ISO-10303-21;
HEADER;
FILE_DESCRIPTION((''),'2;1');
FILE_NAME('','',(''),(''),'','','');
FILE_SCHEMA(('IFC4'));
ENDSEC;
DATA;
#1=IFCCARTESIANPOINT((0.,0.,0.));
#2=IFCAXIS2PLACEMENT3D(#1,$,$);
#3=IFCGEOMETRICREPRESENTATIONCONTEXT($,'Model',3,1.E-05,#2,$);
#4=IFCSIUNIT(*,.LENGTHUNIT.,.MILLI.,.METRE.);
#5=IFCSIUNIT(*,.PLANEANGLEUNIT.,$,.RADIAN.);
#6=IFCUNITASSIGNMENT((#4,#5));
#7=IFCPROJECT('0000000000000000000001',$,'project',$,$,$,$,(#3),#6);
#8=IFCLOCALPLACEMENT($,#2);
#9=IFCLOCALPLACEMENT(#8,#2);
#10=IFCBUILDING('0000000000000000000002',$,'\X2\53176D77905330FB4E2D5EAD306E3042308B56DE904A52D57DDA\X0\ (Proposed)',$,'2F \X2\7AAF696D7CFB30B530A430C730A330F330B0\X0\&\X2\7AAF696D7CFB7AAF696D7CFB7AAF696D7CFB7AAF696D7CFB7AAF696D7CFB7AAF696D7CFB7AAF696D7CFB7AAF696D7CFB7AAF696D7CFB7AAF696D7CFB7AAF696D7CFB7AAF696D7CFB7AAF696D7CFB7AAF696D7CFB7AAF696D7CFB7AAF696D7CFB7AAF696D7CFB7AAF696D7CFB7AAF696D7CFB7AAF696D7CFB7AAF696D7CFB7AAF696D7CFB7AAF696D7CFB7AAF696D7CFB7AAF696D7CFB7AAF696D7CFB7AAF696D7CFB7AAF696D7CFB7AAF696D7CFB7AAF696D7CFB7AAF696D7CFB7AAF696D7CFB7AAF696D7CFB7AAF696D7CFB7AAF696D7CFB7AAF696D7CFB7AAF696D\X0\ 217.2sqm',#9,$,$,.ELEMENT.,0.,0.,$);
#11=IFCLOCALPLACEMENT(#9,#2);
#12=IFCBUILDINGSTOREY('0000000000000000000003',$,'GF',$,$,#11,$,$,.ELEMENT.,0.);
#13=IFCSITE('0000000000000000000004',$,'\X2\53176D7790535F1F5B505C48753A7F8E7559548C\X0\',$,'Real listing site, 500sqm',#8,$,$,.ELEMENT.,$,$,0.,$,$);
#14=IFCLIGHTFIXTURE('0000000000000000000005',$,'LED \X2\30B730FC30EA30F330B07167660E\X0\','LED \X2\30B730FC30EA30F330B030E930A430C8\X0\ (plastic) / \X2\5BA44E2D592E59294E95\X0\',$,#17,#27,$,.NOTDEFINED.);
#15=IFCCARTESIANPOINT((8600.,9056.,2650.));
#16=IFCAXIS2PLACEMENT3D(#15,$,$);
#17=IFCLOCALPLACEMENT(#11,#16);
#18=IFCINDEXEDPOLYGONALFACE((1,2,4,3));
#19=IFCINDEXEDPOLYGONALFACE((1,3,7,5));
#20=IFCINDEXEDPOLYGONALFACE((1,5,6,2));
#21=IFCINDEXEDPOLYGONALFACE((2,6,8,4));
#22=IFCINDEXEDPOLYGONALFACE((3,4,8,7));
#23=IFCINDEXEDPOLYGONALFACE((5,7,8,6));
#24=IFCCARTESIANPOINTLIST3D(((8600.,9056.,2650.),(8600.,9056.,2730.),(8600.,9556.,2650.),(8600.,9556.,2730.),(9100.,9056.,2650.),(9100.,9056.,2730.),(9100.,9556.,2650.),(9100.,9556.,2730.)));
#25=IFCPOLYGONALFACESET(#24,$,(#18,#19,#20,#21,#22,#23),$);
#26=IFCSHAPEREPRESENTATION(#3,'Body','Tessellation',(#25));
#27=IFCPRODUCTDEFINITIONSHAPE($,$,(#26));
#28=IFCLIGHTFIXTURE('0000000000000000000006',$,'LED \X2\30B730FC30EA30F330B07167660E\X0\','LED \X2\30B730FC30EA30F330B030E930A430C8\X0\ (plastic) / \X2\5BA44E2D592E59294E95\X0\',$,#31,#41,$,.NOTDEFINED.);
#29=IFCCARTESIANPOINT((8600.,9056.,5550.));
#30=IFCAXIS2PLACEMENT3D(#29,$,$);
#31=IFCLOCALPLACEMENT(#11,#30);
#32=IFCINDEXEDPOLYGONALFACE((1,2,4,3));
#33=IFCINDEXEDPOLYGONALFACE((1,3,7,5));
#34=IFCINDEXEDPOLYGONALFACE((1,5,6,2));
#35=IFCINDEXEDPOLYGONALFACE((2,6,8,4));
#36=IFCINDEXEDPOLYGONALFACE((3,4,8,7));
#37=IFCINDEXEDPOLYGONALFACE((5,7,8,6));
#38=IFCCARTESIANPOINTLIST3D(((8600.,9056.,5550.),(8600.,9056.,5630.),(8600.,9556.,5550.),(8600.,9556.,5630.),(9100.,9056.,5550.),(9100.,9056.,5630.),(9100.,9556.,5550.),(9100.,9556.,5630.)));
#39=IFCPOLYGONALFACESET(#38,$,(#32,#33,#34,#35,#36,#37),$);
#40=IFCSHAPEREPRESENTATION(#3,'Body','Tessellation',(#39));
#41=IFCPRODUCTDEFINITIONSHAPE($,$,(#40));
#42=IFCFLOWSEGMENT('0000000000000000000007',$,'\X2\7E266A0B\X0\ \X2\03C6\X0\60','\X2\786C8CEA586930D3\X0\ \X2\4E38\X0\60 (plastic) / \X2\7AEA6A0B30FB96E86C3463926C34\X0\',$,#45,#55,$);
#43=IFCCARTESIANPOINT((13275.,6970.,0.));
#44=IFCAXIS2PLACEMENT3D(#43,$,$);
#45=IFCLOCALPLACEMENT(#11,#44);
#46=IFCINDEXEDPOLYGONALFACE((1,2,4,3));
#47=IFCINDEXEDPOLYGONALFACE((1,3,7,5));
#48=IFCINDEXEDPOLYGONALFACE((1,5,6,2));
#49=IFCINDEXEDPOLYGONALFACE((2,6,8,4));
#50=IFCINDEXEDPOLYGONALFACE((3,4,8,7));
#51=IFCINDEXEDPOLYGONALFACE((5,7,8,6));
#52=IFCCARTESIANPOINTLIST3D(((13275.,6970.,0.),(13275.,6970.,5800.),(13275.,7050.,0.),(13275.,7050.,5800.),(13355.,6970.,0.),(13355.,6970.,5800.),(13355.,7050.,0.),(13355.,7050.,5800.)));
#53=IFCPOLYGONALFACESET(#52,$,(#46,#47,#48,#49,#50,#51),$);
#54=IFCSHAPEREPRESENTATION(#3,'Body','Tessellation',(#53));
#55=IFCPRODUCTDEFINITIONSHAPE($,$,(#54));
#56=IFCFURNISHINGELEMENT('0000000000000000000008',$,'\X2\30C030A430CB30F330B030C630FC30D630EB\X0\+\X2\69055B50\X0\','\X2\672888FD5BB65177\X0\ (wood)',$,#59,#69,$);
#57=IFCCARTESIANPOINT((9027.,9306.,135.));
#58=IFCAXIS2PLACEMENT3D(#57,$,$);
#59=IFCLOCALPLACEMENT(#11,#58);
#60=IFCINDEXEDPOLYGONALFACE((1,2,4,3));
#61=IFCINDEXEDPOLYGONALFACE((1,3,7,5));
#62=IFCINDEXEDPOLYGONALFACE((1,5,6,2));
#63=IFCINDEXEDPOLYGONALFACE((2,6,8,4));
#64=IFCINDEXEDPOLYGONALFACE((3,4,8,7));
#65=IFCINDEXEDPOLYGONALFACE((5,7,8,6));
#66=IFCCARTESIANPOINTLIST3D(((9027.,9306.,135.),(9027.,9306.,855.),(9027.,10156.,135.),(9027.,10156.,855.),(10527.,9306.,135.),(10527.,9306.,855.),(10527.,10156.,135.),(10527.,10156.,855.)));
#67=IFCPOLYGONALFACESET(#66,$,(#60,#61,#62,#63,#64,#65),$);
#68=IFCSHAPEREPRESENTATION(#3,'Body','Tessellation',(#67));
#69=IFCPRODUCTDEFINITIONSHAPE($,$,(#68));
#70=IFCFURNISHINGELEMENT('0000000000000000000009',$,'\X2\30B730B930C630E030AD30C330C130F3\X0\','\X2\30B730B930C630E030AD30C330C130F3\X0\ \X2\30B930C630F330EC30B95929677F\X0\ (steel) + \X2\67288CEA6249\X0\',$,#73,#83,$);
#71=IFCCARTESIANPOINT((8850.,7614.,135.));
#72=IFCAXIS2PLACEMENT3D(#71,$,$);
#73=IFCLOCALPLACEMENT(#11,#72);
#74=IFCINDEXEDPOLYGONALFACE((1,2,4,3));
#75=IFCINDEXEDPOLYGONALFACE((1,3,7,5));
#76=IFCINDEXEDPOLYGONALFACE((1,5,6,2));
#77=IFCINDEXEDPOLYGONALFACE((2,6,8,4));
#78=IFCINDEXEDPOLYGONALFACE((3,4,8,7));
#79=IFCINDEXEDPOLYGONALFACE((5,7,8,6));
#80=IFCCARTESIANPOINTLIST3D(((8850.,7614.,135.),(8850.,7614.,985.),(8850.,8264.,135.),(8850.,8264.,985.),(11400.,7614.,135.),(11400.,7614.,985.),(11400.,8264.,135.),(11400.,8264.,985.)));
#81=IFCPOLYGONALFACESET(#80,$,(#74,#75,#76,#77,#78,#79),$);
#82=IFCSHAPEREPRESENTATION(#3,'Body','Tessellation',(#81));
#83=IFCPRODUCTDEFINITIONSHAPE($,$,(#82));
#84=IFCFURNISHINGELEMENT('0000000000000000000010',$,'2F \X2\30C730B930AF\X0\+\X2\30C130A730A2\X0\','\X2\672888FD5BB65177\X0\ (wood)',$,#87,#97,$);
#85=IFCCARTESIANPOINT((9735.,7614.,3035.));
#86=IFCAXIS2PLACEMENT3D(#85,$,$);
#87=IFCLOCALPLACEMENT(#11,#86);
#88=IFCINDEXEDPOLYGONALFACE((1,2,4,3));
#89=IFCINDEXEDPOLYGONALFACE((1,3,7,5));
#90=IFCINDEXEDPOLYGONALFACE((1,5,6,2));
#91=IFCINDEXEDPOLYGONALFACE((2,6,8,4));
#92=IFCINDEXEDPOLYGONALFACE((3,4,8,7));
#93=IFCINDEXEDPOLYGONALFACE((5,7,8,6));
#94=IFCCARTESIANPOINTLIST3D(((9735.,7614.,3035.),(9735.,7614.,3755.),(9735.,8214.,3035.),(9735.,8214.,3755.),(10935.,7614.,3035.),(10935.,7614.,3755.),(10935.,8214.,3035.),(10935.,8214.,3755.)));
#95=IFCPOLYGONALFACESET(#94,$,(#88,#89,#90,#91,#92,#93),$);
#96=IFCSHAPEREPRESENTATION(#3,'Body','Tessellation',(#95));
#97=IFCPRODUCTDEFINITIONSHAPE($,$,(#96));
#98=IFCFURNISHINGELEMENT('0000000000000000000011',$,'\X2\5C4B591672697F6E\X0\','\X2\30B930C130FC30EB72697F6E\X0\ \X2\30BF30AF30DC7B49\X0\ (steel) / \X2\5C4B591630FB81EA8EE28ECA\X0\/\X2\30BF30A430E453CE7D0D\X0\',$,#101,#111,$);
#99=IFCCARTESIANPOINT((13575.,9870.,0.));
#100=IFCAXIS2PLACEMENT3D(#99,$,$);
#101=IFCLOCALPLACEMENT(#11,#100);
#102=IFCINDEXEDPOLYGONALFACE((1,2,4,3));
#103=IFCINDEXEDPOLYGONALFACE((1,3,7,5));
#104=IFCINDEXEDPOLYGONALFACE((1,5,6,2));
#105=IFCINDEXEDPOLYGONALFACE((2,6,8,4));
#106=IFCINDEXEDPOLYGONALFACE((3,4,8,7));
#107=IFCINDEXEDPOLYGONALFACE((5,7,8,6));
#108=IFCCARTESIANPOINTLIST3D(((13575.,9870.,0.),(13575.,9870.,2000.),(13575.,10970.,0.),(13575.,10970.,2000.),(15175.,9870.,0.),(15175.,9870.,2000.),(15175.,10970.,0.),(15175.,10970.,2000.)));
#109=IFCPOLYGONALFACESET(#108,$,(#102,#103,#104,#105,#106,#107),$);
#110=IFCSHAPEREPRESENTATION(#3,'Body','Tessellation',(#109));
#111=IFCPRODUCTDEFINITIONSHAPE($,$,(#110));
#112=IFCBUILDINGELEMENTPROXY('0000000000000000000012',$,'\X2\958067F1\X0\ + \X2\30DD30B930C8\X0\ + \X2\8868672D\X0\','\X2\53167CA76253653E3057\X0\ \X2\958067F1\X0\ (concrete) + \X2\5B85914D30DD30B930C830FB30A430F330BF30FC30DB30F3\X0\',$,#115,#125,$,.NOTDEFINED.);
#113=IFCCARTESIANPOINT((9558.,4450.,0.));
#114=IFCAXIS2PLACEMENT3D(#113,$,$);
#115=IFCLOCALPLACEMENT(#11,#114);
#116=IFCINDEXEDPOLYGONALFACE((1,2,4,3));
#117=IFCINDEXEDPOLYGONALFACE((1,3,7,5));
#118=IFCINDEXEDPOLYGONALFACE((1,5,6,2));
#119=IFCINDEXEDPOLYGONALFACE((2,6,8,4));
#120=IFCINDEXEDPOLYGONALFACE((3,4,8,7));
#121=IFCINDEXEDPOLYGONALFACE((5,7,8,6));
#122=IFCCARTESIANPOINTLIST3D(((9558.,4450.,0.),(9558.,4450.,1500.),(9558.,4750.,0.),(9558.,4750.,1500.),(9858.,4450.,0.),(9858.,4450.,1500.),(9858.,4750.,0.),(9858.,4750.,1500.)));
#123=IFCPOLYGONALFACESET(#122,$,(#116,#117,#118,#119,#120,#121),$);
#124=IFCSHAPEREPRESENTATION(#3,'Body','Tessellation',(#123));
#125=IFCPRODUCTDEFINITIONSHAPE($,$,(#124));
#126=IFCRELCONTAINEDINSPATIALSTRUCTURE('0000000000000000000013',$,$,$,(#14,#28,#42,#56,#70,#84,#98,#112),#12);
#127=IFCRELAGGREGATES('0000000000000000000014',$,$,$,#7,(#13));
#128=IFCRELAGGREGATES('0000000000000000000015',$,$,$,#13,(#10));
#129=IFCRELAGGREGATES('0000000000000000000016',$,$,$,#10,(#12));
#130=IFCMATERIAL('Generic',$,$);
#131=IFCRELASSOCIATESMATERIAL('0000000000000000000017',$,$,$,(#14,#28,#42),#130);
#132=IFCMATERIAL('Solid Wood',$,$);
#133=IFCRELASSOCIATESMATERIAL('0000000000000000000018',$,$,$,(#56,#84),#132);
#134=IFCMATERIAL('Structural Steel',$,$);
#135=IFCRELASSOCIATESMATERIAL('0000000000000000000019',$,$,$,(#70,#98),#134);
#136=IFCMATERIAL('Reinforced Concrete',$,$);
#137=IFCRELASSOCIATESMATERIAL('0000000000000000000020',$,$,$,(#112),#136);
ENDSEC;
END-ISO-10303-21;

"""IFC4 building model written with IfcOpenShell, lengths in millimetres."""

from ifc_helpers import new_model, si_unit, frame, frame_2d, origin, place, context, project, spatial, rectangle, extrude, material, element, save


model = new_model("IFC4")

# Units and contexts
model_context = context("Model", 3, precision=1e-05, world=origin())
ifc_project = project(units=[si_unit("LENGTHUNIT", "METRE", prefix="MILLI"), si_unit("PLANEANGLEUNIT", "RADIAN")], contexts=[model_context])

# Site, building, storey
site_placement = place(None, origin())
site = spatial("IfcSite", under=ifc_project, at=site_placement, Name="北海道弟子屈町美留和", ObjectType="Real listing site, 500sqm", CompositionType="ELEMENT", RefElevation=0.0)
building_placement = place(site_placement, origin())
building = spatial("IfcBuilding", under=site, at=building_placement, Name="北海道・中庭のある回遊動線 (Proposed)", ObjectType="2F 窯業系サイディング&窯業系窯業系窯業系窯業系窯業系窯業系窯業系窯業系窯業系窯業系窯業系窯業系窯業系窯業系窯業系窯業系窯業系窯業系窯業系窯業系窯業系窯業系窯業系窯業系窯業系窯業系窯業系窯業系窯業系窯業系窯業系窯業系窯業系窯業系窯業系窯業系窯業 217.2sqm", CompositionType="ELEMENT", ElevationOfRefHeight=0.0, ElevationOfTerrain=0.0)
storey_placement = place(building_placement, origin())
storey = spatial("IfcBuildingStorey", under=building, at=storey_placement, Name="GF", CompositionType="ELEMENT", Elevation=0.0)

# Shared definitions
ifc_material_1 = material(Name="Solid Wood")

# Shared definitions
ifc_material_2 = material(Name="Reinforced Concrete")

# Shared definitions
ifc_material_3 = material(Name="Structural Steel")

# Shared definitions
ifc_material_4 = material(Name="Generic")

# Light fixtures
light_fixture_1_placement = place(storey_placement, frame((8600.0, 9056.0, 2650.0)))
element("IfcLightFixture", 1, at=light_fixture_1_placement, inside=storey, material=ifc_material_4, Name="LED シーリング照明", Description="LED シーリングライト (plastic) / 室中央天井", PredefinedType="NOTDEFINED", context=model_context, shape_type="SweptSolid", body=[
    extrude(rectangle(XDim=500.0, YDim=500.0, at=frame_2d((250.0, 250.0))), frame((8600.0, 9056.0, 2650.0)), (0.0, 0.0, 1.0), 80.0),
])
light_fixture_2_placement = place(storey_placement, frame((8600.0, 9056.0, 5550.0)))
element("IfcLightFixture", 2, at=light_fixture_2_placement, inside=storey, material=ifc_material_4, Name="LED シーリング照明", Description="LED シーリングライト (plastic) / 室中央天井", PredefinedType="NOTDEFINED", context=model_context, shape_type="SweptSolid", body=[
    extrude(rectangle(XDim=500.0, YDim=500.0, at=frame_2d((250.0, 250.0))), frame((8600.0, 9056.0, 5550.0)), (0.0, 0.0, 1.0), 80.0),
])

# Flow segment
flow_segment_placement = place(storey_placement, frame((13275.0, 6970.0, 0.0)))
element("IfcFlowSegment", 3, at=flow_segment_placement, inside=storey, material=ifc_material_4, Name="縦樋 φ60", Description="硬質塩ビ 丸60 (plastic) / 竪樋・雨水排水", context=model_context, shape_type="SweptSolid", body=[
    extrude(rectangle(XDim=80.0, YDim=80.0, at=frame_2d((40.0, 40.0))), frame((13275.0, 6970.0, 0.0)), (0.0, 0.0, 1.0), 5800.0),
])

# Furnishing elements
furnishing_1_placement = place(storey_placement, frame((9027.0, 9306.0, 135.0)))
element("IfcFurnishingElement", 4, at=furnishing_1_placement, inside=storey, material=ifc_material_1, Name="ダイニングテーブル+椅子", Description="木製家具 (wood)", context=model_context, shape_type="SweptSolid", body=[
    extrude(rectangle(XDim=1500.0, YDim=850.0, at=frame_2d((750.0, 425.0))), frame((9027.0, 9306.0, 135.0)), (0.0, 0.0, 1.0), 720.0),
])
furnishing_2_placement = place(storey_placement, frame((8850.0, 7614.0, 135.0)))
element("IfcFurnishingElement", 5, at=furnishing_2_placement, inside=storey, material=ifc_material_3, Name="システムキッチン", Description="システムキッチン ステンレス天板 (steel) + 木質扉", context=model_context, shape_type="SweptSolid", body=[
    extrude(rectangle(XDim=2550.0, YDim=650.0, at=frame_2d((1275.0, 325.0))), frame((8850.0, 7614.0, 135.0)), (0.0, 0.0, 1.0), 850.0),
])
furnishing_3_placement = place(storey_placement, frame((9735.0, 7614.0, 3035.0)))
element("IfcFurnishingElement", 6, at=furnishing_3_placement, inside=storey, material=ifc_material_1, Name="2F デスク+チェア", Description="木製家具 (wood)", context=model_context, shape_type="SweptSolid", body=[
    extrude(rectangle(XDim=1200.0, YDim=600.0, at=frame_2d((600.0, 300.0))), frame((9735.0, 7614.0, 3035.0)), (0.0, 0.0, 1.0), 720.0),
])
furnishing_4_placement = place(storey_placement, frame((13575.0, 9870.0, 0.0)))
element("IfcFurnishingElement", 7, at=furnishing_4_placement, inside=storey, material=ifc_material_3, Name="屋外物置", Description="スチール物置 タクボ等 (steel) / 屋外・自転車/タイヤ収納", context=model_context, shape_type="SweptSolid", body=[
    extrude(rectangle(XDim=1600.0, YDim=1100.0, at=frame_2d((800.0, 550.0))), frame((13575.0, 9870.0, 0.0)), (0.0, 0.0, 1.0), 2000.0),
])

# Building element proxy
proxy_placement = place(storey_placement, frame((9558.0, 4450.0, 0.0)))
element("IfcBuildingElementProxy", 8, at=proxy_placement, inside=storey, material=ifc_material_2, Name="門柱 + ポスト + 表札", Description="化粧打放し 門柱 (concrete) + 宅配ポスト・インターホン", PredefinedType="NOTDEFINED", context=model_context, shape_type="SweptSolid", body=[
    extrude(rectangle(XDim=300.0, YDim=300.0, at=frame_2d((150.0, 150.0))), frame((9558.0, 4450.0, 0.0)), (0.0, 0.0, 1.0), 1500.0),
])

save(model, "model.ifc")
